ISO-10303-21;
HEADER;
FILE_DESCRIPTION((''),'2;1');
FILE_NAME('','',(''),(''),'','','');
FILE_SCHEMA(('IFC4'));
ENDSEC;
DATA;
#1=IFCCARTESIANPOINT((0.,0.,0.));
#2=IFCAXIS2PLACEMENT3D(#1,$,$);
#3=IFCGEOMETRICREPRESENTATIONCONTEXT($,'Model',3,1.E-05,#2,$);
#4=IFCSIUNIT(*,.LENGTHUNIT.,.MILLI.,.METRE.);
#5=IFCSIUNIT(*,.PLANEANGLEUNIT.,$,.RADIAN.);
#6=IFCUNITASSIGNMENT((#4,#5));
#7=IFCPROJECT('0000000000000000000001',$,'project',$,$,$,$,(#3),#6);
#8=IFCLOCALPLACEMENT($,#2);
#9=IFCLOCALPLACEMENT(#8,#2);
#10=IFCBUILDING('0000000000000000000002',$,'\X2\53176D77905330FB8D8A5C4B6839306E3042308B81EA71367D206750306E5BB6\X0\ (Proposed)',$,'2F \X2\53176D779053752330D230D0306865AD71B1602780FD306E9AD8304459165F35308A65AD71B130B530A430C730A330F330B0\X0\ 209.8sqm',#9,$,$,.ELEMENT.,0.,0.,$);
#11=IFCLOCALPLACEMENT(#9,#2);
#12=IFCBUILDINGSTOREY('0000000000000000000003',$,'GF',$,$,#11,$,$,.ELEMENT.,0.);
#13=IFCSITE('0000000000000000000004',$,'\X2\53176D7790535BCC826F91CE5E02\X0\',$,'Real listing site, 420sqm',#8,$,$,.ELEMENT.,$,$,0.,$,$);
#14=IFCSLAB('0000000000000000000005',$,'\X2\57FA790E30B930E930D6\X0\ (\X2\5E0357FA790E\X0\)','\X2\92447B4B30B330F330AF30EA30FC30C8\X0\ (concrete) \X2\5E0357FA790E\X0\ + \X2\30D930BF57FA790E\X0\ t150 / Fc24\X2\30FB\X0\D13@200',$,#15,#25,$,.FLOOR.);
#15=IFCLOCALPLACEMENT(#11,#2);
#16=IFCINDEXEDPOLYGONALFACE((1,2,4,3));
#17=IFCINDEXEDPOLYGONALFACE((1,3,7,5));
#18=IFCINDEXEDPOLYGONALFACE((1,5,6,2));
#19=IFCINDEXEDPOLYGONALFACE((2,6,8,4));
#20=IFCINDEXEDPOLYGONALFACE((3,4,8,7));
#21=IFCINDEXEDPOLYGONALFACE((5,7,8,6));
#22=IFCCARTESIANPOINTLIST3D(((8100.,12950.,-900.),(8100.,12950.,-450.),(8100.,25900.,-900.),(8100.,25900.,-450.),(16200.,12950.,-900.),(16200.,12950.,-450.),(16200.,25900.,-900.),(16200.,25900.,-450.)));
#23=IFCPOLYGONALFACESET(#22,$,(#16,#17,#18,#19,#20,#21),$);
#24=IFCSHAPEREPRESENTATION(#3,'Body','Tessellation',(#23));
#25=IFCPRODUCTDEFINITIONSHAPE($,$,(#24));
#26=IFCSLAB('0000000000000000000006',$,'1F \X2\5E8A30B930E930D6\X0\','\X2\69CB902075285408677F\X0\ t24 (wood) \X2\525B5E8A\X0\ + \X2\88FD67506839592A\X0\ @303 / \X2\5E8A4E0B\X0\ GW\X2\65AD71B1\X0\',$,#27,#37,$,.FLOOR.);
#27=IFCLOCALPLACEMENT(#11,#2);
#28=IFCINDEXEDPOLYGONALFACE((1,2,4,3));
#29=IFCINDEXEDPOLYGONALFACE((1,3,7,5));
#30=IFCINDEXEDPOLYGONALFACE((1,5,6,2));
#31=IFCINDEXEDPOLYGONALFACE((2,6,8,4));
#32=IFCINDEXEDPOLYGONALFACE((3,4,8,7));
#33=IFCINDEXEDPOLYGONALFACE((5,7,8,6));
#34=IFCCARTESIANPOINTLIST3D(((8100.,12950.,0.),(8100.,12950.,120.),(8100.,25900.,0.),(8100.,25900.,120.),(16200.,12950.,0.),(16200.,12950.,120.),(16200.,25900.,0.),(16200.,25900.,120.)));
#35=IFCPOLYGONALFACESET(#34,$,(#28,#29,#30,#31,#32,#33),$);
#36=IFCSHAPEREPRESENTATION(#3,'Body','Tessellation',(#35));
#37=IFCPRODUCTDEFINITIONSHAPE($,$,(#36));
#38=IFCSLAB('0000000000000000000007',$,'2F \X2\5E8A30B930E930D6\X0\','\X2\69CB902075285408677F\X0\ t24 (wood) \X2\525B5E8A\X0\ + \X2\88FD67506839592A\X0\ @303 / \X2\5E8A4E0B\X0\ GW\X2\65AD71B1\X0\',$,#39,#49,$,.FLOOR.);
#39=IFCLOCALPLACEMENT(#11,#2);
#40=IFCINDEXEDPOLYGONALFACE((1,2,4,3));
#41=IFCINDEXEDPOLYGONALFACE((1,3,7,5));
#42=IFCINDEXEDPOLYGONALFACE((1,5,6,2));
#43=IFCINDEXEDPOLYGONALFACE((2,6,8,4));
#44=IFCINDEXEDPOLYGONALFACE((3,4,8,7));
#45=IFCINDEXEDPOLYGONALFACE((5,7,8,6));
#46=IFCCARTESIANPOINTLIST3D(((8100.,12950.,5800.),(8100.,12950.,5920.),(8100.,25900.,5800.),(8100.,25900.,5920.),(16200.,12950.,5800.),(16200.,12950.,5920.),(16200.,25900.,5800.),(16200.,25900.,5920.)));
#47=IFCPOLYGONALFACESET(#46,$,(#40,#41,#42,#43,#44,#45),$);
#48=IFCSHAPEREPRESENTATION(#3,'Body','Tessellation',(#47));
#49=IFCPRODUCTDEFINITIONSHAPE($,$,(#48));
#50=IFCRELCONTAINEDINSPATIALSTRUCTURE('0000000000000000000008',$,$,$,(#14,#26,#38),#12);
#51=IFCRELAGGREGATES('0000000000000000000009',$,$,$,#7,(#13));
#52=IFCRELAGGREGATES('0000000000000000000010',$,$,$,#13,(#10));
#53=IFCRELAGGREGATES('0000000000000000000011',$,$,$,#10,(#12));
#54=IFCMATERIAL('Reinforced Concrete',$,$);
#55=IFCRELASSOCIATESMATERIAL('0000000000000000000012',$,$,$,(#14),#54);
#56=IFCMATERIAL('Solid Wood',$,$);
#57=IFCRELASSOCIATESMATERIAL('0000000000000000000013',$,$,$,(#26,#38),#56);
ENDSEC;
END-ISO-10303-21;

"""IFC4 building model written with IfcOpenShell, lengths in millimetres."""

from ifc_helpers import new_model, si_unit, frame, frame_2d, origin, place, context, project, spatial, rectangle, extrude, material, element, save


model = new_model("IFC4")

# Units and contexts
model_context = context("Model", 3, precision=1e-05, world=origin())
ifc_project = project(units=[si_unit("LENGTHUNIT", "METRE", prefix="MILLI"), si_unit("PLANEANGLEUNIT", "RADIAN")], contexts=[model_context])

# Site, building, storey
site_placement = place(None, origin())
site = spatial("IfcSite", under=ifc_project, at=site_placement, Name="北海道富良野市", ObjectType="Real listing site, 420sqm", CompositionType="ELEMENT", RefElevation=0.0)
building_placement = place(site_placement, origin())
building = spatial("IfcBuilding", under=site, at=building_placement, Name="北海道・越屋根のある自然素材の家 (Proposed)", ObjectType="2F 北海道産ヒバと断熱性能の高い外張り断熱サイディング 209.8sqm", CompositionType="ELEMENT", ElevationOfRefHeight=0.0, ElevationOfTerrain=0.0)
storey_placement = place(building_placement, origin())
storey = spatial("IfcBuildingStorey", under=building, at=storey_placement, Name="GF", CompositionType="ELEMENT", Elevation=0.0)

# Shared definitions
ifc_material_1 = material(Name="Solid Wood")

# Slabs
ifc_material_2 = material(Name="Reinforced Concrete")
slab_1_placement = place(storey_placement, frame((4050.0, 6475.0, -450.0)))
element("IfcSlab", 1, at=slab_1_placement, inside=storey, material=ifc_material_2, Name="基礎スラブ (布基礎)", Description="鉄筋コンクリート (concrete) 布基礎 + ベタ基礎 t150 / Fc24・D13@200", PredefinedType="FLOOR", context=model_context, shape_type="SweptSolid", body=[
    extrude(rectangle(XDim=8100.0, YDim=12950.0, at=frame_2d((4050.0, 6475.0))), frame((4050.0, 6475.0, -450.0)), (0.0, 0.0, 1.0), 450.0),
])
slab_2_placement = place(storey_placement, frame((4050.0, 6475.0, 0.0)))
element("IfcSlab", 2, at=slab_2_placement, inside=storey, material=ifc_material_1, Name="1F 床スラブ", Description="構造用合板 t24 (wood) 剛床 + 製材根太 @303 / 床下 GW断熱", PredefinedType="FLOOR", context=model_context, shape_type="SweptSolid", body=[
    extrude(rectangle(XDim=8100.0, YDim=12950.0, at=frame_2d((4050.0, 6475.0))), frame((4050.0, 6475.0, 0.0)), (0.0, 0.0, 1.0), 120.0),
])
slab_3_placement = place(storey_placement, frame((4050.0, 6475.0, 2900.0)))
element("IfcSlab", 3, at=slab_3_placement, inside=storey, material=ifc_material_1, Name="2F 床スラブ", Description="構造用合板 t24 (wood) 剛床 + 製材根太 @303 / 床下 GW断熱", PredefinedType="FLOOR", context=model_context, shape_type="SweptSolid", body=[
    extrude(rectangle(XDim=8100.0, YDim=12950.0, at=frame_2d((4050.0, 6475.0))), frame((4050.0, 6475.0, 2900.0)), (0.0, 0.0, 1.0), 120.0),
])

save(model, "model.ifc")
